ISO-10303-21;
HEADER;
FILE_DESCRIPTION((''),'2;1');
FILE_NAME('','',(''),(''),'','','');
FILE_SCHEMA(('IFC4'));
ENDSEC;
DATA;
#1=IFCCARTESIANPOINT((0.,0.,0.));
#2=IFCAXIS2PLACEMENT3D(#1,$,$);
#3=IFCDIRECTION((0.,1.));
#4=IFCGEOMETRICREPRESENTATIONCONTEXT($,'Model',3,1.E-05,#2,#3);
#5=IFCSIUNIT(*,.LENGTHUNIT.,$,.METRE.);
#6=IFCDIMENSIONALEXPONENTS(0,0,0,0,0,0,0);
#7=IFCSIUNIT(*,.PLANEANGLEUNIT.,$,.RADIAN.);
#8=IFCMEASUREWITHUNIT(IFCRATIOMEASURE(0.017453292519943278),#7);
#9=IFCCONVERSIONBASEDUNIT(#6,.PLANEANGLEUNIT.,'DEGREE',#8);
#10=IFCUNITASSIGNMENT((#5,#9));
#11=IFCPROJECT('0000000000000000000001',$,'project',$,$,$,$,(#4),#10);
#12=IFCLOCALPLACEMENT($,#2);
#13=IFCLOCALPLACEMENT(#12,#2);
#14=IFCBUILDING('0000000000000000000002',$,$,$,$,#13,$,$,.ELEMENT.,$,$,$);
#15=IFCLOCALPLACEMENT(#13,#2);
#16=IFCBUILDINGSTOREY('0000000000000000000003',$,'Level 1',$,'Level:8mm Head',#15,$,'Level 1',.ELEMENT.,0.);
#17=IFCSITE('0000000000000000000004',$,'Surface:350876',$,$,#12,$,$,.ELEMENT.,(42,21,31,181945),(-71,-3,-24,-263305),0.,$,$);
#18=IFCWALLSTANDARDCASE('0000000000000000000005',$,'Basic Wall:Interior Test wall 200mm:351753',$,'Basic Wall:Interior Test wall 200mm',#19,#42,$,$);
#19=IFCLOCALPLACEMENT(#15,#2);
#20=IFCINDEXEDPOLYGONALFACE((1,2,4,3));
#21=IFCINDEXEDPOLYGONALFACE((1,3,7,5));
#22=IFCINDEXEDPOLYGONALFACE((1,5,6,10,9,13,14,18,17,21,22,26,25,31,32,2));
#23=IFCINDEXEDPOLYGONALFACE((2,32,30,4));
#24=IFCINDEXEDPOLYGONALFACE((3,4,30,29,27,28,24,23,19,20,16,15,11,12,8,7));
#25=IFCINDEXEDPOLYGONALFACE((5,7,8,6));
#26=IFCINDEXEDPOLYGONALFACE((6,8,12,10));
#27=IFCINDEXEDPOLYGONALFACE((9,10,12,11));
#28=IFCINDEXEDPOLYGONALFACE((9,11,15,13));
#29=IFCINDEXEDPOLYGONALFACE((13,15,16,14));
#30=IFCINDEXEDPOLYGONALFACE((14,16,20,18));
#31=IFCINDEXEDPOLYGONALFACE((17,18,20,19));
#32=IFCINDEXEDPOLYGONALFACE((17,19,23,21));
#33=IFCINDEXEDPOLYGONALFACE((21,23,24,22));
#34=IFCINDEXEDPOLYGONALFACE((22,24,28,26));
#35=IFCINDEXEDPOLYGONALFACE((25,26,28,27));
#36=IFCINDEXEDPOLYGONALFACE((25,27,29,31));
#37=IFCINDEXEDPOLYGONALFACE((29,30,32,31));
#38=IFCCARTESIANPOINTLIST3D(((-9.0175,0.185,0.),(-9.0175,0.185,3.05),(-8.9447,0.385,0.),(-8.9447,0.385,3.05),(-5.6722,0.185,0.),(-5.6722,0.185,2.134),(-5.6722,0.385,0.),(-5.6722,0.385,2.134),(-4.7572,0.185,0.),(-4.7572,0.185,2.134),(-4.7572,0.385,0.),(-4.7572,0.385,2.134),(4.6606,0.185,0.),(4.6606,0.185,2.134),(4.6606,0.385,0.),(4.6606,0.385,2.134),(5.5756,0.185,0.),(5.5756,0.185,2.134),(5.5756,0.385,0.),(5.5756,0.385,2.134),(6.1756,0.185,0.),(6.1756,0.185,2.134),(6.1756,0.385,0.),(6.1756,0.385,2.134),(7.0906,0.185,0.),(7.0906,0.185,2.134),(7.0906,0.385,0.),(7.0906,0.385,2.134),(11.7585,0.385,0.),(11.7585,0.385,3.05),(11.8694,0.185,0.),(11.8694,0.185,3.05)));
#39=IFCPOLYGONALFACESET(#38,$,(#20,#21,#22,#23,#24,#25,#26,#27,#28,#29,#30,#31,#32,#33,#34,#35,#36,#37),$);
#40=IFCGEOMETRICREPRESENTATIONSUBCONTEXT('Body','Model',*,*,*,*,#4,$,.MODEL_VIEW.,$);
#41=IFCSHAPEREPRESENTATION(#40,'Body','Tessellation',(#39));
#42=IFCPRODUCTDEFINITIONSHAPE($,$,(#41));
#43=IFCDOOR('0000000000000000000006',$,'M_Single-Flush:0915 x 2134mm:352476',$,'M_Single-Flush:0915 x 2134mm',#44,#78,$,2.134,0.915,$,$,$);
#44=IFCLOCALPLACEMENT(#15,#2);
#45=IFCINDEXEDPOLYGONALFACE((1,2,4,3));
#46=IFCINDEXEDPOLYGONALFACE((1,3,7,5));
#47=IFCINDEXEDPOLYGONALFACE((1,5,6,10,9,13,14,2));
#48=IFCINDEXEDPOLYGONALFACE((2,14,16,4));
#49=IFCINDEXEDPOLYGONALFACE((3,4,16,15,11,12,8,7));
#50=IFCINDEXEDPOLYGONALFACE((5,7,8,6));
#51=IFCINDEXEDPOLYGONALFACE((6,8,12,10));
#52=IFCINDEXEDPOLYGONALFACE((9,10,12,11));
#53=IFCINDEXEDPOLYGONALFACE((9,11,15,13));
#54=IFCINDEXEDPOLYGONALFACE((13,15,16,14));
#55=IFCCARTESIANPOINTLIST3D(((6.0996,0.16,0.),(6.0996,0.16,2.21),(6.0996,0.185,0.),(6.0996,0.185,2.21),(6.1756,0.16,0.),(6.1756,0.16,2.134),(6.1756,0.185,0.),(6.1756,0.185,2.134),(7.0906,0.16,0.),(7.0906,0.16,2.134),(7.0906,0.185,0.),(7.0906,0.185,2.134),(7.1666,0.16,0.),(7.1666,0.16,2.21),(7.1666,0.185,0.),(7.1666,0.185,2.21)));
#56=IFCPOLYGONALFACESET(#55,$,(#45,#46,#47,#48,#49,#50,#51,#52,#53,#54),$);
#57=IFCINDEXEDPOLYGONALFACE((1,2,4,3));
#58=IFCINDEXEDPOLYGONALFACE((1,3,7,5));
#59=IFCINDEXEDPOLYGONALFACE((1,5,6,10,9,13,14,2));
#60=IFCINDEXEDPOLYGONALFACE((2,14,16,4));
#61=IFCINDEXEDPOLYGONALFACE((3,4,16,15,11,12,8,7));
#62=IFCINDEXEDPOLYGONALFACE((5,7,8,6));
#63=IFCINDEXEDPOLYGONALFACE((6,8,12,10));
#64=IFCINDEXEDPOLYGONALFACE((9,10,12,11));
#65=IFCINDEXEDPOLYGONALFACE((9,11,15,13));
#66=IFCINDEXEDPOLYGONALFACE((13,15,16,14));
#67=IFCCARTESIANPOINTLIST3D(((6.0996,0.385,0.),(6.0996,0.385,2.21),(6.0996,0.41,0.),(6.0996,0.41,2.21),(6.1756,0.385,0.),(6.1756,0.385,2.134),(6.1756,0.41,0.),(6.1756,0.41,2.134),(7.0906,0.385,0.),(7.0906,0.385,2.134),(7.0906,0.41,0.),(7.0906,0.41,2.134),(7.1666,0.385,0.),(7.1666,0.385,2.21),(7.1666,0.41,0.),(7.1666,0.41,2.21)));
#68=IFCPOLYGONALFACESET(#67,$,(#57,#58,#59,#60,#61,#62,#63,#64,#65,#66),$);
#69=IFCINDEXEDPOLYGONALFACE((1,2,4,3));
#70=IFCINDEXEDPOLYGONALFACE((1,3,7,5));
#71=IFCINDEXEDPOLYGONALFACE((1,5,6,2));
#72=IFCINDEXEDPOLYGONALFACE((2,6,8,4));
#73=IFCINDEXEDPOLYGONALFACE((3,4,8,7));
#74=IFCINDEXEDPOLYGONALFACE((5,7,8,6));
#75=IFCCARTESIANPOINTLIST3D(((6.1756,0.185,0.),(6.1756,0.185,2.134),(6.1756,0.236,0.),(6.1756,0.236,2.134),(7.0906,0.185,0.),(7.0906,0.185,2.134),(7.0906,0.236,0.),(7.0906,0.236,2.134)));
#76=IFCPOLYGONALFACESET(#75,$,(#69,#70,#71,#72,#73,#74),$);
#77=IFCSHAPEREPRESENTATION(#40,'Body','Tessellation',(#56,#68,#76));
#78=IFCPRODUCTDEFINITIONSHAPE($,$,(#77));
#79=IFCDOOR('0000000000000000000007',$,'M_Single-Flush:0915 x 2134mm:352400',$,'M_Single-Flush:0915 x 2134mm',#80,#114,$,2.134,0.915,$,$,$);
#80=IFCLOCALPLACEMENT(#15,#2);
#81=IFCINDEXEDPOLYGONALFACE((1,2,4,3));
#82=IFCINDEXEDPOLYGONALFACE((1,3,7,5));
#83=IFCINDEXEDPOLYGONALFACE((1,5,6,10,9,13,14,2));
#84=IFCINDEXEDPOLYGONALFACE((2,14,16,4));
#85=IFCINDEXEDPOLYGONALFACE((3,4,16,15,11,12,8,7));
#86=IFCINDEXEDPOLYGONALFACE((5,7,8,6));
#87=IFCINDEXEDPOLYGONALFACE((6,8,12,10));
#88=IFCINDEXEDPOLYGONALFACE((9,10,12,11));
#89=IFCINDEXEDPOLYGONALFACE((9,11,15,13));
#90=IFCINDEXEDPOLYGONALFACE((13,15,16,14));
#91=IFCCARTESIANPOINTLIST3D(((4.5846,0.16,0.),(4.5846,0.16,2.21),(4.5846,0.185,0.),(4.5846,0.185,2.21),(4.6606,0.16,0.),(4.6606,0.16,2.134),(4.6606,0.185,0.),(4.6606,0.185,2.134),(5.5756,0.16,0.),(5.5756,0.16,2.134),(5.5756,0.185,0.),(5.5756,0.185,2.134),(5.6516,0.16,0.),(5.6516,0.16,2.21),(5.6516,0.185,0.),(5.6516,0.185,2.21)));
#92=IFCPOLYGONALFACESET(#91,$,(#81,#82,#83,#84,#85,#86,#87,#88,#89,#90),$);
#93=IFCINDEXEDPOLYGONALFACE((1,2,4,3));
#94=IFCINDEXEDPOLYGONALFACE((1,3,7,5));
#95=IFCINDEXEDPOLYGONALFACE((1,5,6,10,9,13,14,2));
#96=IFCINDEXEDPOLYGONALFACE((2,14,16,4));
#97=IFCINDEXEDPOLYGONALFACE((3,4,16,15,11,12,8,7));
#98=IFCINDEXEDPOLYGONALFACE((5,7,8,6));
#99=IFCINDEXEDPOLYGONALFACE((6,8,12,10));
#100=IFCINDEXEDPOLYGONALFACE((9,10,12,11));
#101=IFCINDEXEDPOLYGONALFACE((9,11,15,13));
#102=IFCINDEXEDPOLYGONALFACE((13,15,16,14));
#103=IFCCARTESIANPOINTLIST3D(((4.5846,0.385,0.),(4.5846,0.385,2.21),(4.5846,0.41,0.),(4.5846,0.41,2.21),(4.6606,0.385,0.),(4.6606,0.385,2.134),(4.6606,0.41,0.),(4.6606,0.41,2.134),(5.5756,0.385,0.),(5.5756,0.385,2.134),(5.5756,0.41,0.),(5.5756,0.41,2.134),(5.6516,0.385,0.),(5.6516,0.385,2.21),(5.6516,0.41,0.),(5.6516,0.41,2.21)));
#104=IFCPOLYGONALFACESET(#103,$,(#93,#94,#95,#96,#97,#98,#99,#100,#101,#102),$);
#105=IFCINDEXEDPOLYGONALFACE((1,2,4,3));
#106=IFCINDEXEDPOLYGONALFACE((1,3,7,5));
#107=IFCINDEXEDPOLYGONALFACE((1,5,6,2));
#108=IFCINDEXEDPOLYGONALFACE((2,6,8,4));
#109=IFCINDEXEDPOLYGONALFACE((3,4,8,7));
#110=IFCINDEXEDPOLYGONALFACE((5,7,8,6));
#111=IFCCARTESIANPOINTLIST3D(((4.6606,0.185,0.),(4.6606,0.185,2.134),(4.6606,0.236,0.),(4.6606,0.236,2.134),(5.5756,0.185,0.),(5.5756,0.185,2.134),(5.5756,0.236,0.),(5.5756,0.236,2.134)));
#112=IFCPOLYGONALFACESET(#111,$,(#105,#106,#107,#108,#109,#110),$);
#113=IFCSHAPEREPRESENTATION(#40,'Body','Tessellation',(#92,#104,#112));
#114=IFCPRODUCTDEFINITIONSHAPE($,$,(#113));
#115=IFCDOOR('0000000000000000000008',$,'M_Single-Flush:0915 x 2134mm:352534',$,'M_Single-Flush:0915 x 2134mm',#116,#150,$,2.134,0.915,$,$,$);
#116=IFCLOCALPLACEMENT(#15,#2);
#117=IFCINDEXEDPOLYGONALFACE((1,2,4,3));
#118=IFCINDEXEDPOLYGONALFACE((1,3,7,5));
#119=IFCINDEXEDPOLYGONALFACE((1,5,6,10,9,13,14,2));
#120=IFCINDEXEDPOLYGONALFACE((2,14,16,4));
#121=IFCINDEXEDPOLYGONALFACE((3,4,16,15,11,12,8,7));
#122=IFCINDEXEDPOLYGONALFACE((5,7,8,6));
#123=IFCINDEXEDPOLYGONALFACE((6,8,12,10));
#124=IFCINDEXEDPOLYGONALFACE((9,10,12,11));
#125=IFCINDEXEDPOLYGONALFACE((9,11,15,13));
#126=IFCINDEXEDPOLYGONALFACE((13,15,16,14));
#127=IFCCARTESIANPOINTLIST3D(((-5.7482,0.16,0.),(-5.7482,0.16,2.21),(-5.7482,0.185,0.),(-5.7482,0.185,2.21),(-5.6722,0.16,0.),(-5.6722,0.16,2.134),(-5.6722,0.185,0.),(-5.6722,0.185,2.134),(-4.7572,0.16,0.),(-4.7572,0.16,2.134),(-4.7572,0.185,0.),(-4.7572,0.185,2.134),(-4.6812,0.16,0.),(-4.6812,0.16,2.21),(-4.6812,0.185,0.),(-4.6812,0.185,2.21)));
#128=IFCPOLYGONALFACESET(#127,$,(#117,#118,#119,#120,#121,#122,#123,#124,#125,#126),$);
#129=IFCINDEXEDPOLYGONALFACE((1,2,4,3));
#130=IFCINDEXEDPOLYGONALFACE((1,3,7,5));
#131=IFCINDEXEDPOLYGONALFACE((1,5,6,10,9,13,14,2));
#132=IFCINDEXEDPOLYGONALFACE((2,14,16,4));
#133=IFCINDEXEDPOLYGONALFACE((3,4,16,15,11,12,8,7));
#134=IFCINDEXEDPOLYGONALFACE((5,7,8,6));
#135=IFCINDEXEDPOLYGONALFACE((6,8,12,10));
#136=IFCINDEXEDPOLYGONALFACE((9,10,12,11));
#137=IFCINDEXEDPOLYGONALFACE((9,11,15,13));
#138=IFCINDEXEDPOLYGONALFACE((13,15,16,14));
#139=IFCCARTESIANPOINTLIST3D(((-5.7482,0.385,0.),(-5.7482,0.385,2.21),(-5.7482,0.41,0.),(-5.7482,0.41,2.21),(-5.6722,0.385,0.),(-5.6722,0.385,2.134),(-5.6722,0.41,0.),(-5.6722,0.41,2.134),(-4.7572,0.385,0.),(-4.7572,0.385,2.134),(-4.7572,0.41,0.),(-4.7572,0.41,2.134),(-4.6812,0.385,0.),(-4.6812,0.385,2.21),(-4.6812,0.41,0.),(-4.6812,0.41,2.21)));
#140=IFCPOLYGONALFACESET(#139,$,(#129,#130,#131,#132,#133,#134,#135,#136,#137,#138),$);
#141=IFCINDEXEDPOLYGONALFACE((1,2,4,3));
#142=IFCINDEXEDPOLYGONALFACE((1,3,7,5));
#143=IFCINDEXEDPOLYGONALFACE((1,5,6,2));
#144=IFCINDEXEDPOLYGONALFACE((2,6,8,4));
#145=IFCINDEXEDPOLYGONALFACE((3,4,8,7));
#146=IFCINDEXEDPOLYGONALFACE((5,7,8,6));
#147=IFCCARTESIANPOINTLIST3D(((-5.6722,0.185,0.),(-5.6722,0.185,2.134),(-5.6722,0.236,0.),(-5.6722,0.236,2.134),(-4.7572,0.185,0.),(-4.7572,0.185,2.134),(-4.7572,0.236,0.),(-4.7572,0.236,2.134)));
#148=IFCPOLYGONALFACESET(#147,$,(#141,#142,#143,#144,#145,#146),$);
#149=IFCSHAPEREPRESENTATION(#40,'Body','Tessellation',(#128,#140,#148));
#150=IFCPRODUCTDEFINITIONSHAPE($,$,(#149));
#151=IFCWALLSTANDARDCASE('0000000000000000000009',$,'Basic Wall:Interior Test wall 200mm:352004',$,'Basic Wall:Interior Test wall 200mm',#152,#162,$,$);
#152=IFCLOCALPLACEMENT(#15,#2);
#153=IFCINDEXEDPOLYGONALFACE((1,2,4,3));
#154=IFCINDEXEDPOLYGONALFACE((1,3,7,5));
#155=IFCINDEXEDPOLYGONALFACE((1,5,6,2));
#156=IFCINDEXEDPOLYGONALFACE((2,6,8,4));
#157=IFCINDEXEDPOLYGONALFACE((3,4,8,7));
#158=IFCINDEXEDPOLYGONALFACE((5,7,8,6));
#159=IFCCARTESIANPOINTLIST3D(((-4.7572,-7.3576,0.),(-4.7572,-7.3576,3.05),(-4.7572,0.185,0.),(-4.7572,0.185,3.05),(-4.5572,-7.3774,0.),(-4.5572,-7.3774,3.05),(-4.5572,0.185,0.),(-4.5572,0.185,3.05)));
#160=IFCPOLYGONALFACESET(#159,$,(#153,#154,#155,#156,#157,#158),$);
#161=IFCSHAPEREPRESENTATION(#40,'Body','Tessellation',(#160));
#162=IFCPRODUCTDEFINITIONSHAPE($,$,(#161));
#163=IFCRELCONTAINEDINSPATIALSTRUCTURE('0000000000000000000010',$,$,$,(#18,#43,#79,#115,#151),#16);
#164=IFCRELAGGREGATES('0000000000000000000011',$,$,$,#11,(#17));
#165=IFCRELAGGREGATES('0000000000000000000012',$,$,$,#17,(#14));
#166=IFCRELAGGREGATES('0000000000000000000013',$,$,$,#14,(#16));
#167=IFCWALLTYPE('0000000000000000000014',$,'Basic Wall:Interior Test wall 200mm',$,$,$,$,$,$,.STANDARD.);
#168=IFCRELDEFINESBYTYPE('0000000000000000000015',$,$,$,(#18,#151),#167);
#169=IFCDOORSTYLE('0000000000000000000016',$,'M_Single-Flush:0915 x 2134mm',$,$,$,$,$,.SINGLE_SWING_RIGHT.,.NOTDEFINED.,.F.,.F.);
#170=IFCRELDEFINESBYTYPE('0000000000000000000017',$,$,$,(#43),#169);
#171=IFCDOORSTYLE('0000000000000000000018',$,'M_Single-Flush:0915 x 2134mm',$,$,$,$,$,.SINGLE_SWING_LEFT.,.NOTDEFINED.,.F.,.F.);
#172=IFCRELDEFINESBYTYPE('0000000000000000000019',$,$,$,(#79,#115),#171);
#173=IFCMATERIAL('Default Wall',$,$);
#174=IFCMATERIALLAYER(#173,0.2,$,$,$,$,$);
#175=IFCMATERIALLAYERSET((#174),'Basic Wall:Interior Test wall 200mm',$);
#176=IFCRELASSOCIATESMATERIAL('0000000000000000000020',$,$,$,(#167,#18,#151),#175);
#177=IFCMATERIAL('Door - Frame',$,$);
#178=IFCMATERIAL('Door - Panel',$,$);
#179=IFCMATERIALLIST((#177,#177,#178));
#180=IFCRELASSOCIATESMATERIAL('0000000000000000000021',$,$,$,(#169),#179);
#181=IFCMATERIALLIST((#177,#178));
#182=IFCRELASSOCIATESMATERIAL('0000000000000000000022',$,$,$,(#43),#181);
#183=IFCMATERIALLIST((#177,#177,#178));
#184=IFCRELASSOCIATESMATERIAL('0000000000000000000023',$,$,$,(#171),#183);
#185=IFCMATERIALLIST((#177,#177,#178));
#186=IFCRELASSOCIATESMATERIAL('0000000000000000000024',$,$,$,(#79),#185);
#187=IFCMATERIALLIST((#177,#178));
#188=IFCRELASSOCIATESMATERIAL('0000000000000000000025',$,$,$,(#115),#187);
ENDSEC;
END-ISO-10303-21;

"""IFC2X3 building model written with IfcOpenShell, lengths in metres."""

from ifc_helpers import new_model, entity, si_unit, converted_unit, direction, frame, frame_2d, origin, place, context, subcontext, project, spatial, polyline, rectangle, outline, extrude, clip, bounded_halfspace, source, transform, mapped, material, material_list, layer, layer_set, layer_usage, type_object, type_shapes, element, fill, save


model = new_model("IFC2X3")

# Units and contexts
model_context = context("Model", 3, precision=1e-05, world=origin(), true_north=direction((0.0, 1.0)))
body_context = subcontext(model_context, "Body", "Model", "MODEL_VIEW")
ifc_project = project(units=[si_unit("LENGTHUNIT", "METRE"), converted_unit("PLANEANGLEUNIT", "DEGREE", entity("IfcRatioMeasure", 0.017453292519943278), si_unit("PLANEANGLEUNIT", "RADIAN"), dimensions=[0, 0, 0, 0, 0, 0, 0])], contexts=[model_context])

# Site, building, storey
site_placement = place(None, origin())
site = spatial("IfcSite", under=ifc_project, at=site_placement, Name="Surface:350876", CompositionType="ELEMENT", RefLatitude=(42, 21, 31, 181945), RefLongitude=(-71, -3, -24, -263305), RefElevation=0.0)
building_placement = place(site_placement, origin())
building = spatial("IfcBuilding", under=site, at=building_placement, CompositionType="ELEMENT")
storey_placement = place(building_placement, origin())
storey = spatial("IfcBuildingStorey", under=building, at=storey_placement, Name="Level 1", ObjectType="Level:8mm Head", LongName="Level 1", CompositionType="ELEMENT", Elevation=0.0)

# Shared definitions
ifc_material_1 = material(Name="Default Wall")

# Shared definitions
ifc_layer_1 = layer(ifc_material_1, 0.2)
ifc_layer_set_1 = layer_set([ifc_layer_1], Name="Basic Wall:Interior Test wall 200mm")
wall_type_1 = type_object("IfcWallType", Name="Basic Wall:Interior Test wall 200mm", PredefinedType="STANDARD", material=ifc_layer_set_1)

# Shared definitions
ifc_material_2 = material(Name="Door - Frame")
ifc_material_3 = material(Name="Door - Panel")
ifc_material_list_1 = material_list([ifc_material_2, ifc_material_2, ifc_material_3])
door_style_1 = type_object("IfcDoorStyle", Name="M_Single-Flush:0915 x 2134mm", ConstructionType="NOTDEFINED", OperationType="SINGLE_SWING_RIGHT", ParameterTakesPrecedence=False, Sizeable=False, material=ifc_material_list_1)
shared_shape_1 = source(origin(), body_context, "Body", "SweptSolid", [
    extrude(outline(polyline([(-0.5335, -1.124), (0.5335, -1.124), (0.5335, 1.086), (0.4575, 1.086), (0.4575, -1.048), (-0.4575, -1.048), (-0.4575, 1.086), (-0.5335, 1.086), (-0.5335, -1.124)])), frame((0.4575, 0.2, 1.086), z_axis=(0.0, 1.0, 0.0), x_axis=(1.0, 0.0, 0.0)), (0.0, 0.0, 1.0), 0.025),
    extrude(outline(polyline([(-1.124, -0.5335), (1.086, -0.5335), (1.086, -0.4575), (-1.048, -0.4575), (-1.048, 0.4575), (1.086, 0.4575), (1.086, 0.5335), (-1.124, 0.5335), (-1.124, -0.5335)])), frame((0.4575, -0.025, 1.086), z_axis=(0.0, 1.0, 0.0), x_axis=(0.0, 0.0, -1.0)), (0.0, 0.0, 1.0), 0.025),
    extrude(rectangle(XDim=0.051, YDim=0.915, at=frame_2d((0.0, 0.0), x_axis=(1.0, 0.0))), frame((0.4575, 0.1745, 0.0), z_axis=(0.0, 0.0, 1.0), x_axis=(0.0, 1.0, 0.0)), (0.0, 0.0, 1.0), 2.134),
])
type_shapes(door_style_1, [shared_shape_1])

# Wall, openings, doors
ifc_layer_usage_1 = layer_usage(ifc_layer_set_1, "AXIS2", "NEGATIVE", 0.1)
wall_1_placement = place(storey_placement, frame((-9.0175, 0.285, 0.0)))
wall_1 = element("IfcWallStandardCase", 1, at=wall_1_placement, inside=storey, type_object=wall_type_1, material=ifc_layer_usage_1, Name="Basic Wall:Interior Test wall 200mm:351753", ObjectType="Basic Wall:Interior Test wall 200mm", context=body_context, shape_type="Clipping", body=[
    clip(extrude(outline(polyline([(0.0, -0.1), (4.2603, -0.1), (4.4603, -0.1), (14.7931, -0.1), (14.9931, -0.1), (20.6582, -0.1), (20.8869, -0.1), (20.7761, 0.1), (0.0728, 0.1), (0.0, -0.1)])), origin(), (0.0, 0.0, 1.0), 3.05), bounded_halfspace(frame((0.0, -0.1, 3.05), z_axis=(0.0, 0.0, -1.0), x_axis=(0.224951, 0.97437, 0.0)), True, frame((0.0, -0.1, 3.05)), polyline([(0.0, 0.0), (4.2603, 0.0), (4.4603, 0.0), (14.7931, 0.0), (14.9931, 0.0), (20.6582, 0.0), (20.8869, 0.0), (20.7761, 0.2), (0.0728, 0.2), (0.0, 0.0)]))),
])
opening_1_placement = place(wall_1_placement, frame((14.5931, 0.1, 0.0)))
opening_1 = element("IfcOpeningElement", 2, at=opening_1_placement, cuts=wall_1, ObjectType="Opening", context=body_context, shape_type="SweptSolid", body=[
    extrude(rectangle(XDim=0.915, YDim=2.134, at=frame_2d((1.067, 0.4575), x_axis=(0.0, -1.0))), frame((0.0, 0.0, 0.0), z_axis=(0.0, -1.0, 0.0), x_axis=(0.0, 0.0, 1.0)), (0.0, 0.0, 1.0), 0.2),
])
opening_2_placement = place(wall_1_placement, frame((16.1081, 0.1, 0.0)))
opening_2 = element("IfcOpeningElement", 3, at=opening_2_placement, cuts=wall_1, ObjectType="Opening", context=body_context, shape_type="SweptSolid", body=[
    extrude(rectangle(XDim=0.915, YDim=2.134, at=frame_2d((1.067, 0.4575), x_axis=(0.0, 1.0))), frame((0.0, 0.0, 0.0), z_axis=(0.0, -1.0, 0.0), x_axis=(0.0, 0.0, 1.0)), (0.0, 0.0, 1.0), 0.2),
])
opening_3_placement = place(wall_1_placement, frame((4.2603, 0.1, 0.0)))
opening_3 = element("IfcOpeningElement", 4, at=opening_3_placement, cuts=wall_1, ObjectType="Opening", context=body_context, shape_type="SweptSolid", body=[
    extrude(rectangle(XDim=0.915, YDim=2.134, at=frame_2d((1.067, 0.4575), x_axis=(0.0, -1.0))), frame((0.0, 0.0, 0.0), z_axis=(0.0, -1.0, 0.0), x_axis=(0.0, 0.0, 1.0)), (0.0, 0.0, 1.0), 0.2),
])
ifc_material_list_2 = material_list([ifc_material_2, ifc_material_3])
door_1_placement = place(opening_2_placement, frame((0.0, 0.0, 0.0), z_axis=(0.0, 0.0, 1.0), x_axis=(-1.0, 0.0, 0.0)))
door_1 = element("IfcDoor", 5, at=door_1_placement, inside=storey, type_object=door_style_1, material=ifc_material_list_2, Name="M_Single-Flush:0915 x 2134mm:352476", ObjectType="M_Single-Flush:0915 x 2134mm", OverallHeight=2.134, OverallWidth=0.915, context=body_context, shape_type="MappedRepresentation", body=[
    mapped(shared_shape_1, transform((0.0, 0.0, 0.0), scale=1.0)),
])
fill(opening_2, door_1)
ifc_material_list_3 = material_list([ifc_material_2, ifc_material_2, ifc_material_3])
ifc_material_list_4 = material_list([ifc_material_2, ifc_material_2, ifc_material_3])
door_style_2 = type_object("IfcDoorStyle", Name="M_Single-Flush:0915 x 2134mm", ConstructionType="NOTDEFINED", OperationType="SINGLE_SWING_LEFT", ParameterTakesPrecedence=False, Sizeable=False, material=ifc_material_list_4)
shared_shape_2 = source(origin(), body_context, "Body", "SweptSolid", [
    extrude(outline(polyline([(-0.5335, -1.124), (0.5335, -1.124), (0.5335, 1.086), (0.4575, 1.086), (0.4575, -1.048), (-0.4575, -1.048), (-0.4575, 1.086), (-0.5335, 1.086), (-0.5335, -1.124)])), frame((0.4575, 0.225, 1.086), z_axis=(0.0, -1.0, 0.0), x_axis=(-1.0, 0.0, 0.0)), (0.0, 0.0, 1.0), 0.025),
    extrude(outline(polyline([(-1.124, -0.5335), (1.086, -0.5335), (1.086, -0.4575), (-1.048, -0.4575), (-1.048, 0.4575), (1.086, 0.4575), (1.086, 0.5335), (-1.124, 0.5335), (-1.124, -0.5335)])), frame((0.4575, 0.0, 1.086), z_axis=(0.0, -1.0, 0.0), x_axis=(0.0, 0.0, -1.0)), (0.0, 0.0, 1.0), 0.025),
    extrude(rectangle(XDim=0.915, YDim=0.051, at=frame_2d((0.0, 0.0), x_axis=(1.0, 0.0))), frame((0.4575, 0.1745, 0.0)), (0.0, 0.0, 1.0), 2.134),
])
type_shapes(door_style_2, [shared_shape_2])
door_2_placement = place(opening_1_placement, frame((0.0, 0.0, 0.0), z_axis=(0.0, 0.0, 1.0), x_axis=(-1.0, 0.0, 0.0)))
door_2 = element("IfcDoor", 6, at=door_2_placement, inside=storey, type_object=door_style_2, material=ifc_material_list_3, Name="M_Single-Flush:0915 x 2134mm:352400", ObjectType="M_Single-Flush:0915 x 2134mm", OverallHeight=2.134, OverallWidth=0.915, context=body_context, shape_type="MappedRepresentation", body=[
    mapped(shared_shape_2, transform((0.0, 0.0, 0.0), scale=1.0)),
])
fill(opening_1, door_2)
ifc_material_list_5 = material_list([ifc_material_2, ifc_material_3])
door_3_placement = place(opening_3_placement, frame((0.0, 0.0, 0.0), z_axis=(0.0, 0.0, 1.0), x_axis=(-1.0, 0.0, 0.0)))
door_3 = element("IfcDoor", 7, at=door_3_placement, inside=storey, type_object=door_style_2, material=ifc_material_list_5, Name="M_Single-Flush:0915 x 2134mm:352534", ObjectType="M_Single-Flush:0915 x 2134mm", OverallHeight=2.134, OverallWidth=0.915, context=body_context, shape_type="MappedRepresentation", body=[
    mapped(shared_shape_2, transform((0.0, 0.0, 0.0), scale=1.0)),
])
fill(opening_3, door_3)

# Wall
ifc_layer_usage_2 = layer_usage(ifc_layer_set_1, "AXIS2", "NEGATIVE", 0.1)
wall_2_placement = place(storey_placement, frame((-4.6572, 0.185, 0.0), z_axis=(0.0, 0.0, 1.0), x_axis=(0.0, -1.0, 0.0)))
element("IfcWallStandardCase", 8, at=wall_2_placement, inside=storey, type_object=wall_type_1, material=ifc_layer_usage_2, Name="Basic Wall:Interior Test wall 200mm:352004", ObjectType="Basic Wall:Interior Test wall 200mm", context=body_context, shape_type="Clipping", body=[
    clip(extrude(outline(polyline([(7.5426, -0.1), (7.5624, 0.1), (4.3, 0.1), (4.1, 0.1), (0.0, 0.1), (0.0, -0.1), (7.5426, -0.1)])), origin(), (0.0, 0.0, 1.0), 3.05), bounded_halfspace(frame((0.0, -0.1, 3.05), z_axis=(0.0, 0.0, -1.0), x_axis=(-0.97437, 0.224951, 0.0)), True, frame((0.0, -0.1, 3.05)), polyline([(0.0, 0.0), (7.5426, 0.0), (7.5624, 0.2), (4.3, 0.2), (4.1, 0.2), (0.0, 0.2), (0.0, 0.0)]))),
])

save(model, "model.ifc")
